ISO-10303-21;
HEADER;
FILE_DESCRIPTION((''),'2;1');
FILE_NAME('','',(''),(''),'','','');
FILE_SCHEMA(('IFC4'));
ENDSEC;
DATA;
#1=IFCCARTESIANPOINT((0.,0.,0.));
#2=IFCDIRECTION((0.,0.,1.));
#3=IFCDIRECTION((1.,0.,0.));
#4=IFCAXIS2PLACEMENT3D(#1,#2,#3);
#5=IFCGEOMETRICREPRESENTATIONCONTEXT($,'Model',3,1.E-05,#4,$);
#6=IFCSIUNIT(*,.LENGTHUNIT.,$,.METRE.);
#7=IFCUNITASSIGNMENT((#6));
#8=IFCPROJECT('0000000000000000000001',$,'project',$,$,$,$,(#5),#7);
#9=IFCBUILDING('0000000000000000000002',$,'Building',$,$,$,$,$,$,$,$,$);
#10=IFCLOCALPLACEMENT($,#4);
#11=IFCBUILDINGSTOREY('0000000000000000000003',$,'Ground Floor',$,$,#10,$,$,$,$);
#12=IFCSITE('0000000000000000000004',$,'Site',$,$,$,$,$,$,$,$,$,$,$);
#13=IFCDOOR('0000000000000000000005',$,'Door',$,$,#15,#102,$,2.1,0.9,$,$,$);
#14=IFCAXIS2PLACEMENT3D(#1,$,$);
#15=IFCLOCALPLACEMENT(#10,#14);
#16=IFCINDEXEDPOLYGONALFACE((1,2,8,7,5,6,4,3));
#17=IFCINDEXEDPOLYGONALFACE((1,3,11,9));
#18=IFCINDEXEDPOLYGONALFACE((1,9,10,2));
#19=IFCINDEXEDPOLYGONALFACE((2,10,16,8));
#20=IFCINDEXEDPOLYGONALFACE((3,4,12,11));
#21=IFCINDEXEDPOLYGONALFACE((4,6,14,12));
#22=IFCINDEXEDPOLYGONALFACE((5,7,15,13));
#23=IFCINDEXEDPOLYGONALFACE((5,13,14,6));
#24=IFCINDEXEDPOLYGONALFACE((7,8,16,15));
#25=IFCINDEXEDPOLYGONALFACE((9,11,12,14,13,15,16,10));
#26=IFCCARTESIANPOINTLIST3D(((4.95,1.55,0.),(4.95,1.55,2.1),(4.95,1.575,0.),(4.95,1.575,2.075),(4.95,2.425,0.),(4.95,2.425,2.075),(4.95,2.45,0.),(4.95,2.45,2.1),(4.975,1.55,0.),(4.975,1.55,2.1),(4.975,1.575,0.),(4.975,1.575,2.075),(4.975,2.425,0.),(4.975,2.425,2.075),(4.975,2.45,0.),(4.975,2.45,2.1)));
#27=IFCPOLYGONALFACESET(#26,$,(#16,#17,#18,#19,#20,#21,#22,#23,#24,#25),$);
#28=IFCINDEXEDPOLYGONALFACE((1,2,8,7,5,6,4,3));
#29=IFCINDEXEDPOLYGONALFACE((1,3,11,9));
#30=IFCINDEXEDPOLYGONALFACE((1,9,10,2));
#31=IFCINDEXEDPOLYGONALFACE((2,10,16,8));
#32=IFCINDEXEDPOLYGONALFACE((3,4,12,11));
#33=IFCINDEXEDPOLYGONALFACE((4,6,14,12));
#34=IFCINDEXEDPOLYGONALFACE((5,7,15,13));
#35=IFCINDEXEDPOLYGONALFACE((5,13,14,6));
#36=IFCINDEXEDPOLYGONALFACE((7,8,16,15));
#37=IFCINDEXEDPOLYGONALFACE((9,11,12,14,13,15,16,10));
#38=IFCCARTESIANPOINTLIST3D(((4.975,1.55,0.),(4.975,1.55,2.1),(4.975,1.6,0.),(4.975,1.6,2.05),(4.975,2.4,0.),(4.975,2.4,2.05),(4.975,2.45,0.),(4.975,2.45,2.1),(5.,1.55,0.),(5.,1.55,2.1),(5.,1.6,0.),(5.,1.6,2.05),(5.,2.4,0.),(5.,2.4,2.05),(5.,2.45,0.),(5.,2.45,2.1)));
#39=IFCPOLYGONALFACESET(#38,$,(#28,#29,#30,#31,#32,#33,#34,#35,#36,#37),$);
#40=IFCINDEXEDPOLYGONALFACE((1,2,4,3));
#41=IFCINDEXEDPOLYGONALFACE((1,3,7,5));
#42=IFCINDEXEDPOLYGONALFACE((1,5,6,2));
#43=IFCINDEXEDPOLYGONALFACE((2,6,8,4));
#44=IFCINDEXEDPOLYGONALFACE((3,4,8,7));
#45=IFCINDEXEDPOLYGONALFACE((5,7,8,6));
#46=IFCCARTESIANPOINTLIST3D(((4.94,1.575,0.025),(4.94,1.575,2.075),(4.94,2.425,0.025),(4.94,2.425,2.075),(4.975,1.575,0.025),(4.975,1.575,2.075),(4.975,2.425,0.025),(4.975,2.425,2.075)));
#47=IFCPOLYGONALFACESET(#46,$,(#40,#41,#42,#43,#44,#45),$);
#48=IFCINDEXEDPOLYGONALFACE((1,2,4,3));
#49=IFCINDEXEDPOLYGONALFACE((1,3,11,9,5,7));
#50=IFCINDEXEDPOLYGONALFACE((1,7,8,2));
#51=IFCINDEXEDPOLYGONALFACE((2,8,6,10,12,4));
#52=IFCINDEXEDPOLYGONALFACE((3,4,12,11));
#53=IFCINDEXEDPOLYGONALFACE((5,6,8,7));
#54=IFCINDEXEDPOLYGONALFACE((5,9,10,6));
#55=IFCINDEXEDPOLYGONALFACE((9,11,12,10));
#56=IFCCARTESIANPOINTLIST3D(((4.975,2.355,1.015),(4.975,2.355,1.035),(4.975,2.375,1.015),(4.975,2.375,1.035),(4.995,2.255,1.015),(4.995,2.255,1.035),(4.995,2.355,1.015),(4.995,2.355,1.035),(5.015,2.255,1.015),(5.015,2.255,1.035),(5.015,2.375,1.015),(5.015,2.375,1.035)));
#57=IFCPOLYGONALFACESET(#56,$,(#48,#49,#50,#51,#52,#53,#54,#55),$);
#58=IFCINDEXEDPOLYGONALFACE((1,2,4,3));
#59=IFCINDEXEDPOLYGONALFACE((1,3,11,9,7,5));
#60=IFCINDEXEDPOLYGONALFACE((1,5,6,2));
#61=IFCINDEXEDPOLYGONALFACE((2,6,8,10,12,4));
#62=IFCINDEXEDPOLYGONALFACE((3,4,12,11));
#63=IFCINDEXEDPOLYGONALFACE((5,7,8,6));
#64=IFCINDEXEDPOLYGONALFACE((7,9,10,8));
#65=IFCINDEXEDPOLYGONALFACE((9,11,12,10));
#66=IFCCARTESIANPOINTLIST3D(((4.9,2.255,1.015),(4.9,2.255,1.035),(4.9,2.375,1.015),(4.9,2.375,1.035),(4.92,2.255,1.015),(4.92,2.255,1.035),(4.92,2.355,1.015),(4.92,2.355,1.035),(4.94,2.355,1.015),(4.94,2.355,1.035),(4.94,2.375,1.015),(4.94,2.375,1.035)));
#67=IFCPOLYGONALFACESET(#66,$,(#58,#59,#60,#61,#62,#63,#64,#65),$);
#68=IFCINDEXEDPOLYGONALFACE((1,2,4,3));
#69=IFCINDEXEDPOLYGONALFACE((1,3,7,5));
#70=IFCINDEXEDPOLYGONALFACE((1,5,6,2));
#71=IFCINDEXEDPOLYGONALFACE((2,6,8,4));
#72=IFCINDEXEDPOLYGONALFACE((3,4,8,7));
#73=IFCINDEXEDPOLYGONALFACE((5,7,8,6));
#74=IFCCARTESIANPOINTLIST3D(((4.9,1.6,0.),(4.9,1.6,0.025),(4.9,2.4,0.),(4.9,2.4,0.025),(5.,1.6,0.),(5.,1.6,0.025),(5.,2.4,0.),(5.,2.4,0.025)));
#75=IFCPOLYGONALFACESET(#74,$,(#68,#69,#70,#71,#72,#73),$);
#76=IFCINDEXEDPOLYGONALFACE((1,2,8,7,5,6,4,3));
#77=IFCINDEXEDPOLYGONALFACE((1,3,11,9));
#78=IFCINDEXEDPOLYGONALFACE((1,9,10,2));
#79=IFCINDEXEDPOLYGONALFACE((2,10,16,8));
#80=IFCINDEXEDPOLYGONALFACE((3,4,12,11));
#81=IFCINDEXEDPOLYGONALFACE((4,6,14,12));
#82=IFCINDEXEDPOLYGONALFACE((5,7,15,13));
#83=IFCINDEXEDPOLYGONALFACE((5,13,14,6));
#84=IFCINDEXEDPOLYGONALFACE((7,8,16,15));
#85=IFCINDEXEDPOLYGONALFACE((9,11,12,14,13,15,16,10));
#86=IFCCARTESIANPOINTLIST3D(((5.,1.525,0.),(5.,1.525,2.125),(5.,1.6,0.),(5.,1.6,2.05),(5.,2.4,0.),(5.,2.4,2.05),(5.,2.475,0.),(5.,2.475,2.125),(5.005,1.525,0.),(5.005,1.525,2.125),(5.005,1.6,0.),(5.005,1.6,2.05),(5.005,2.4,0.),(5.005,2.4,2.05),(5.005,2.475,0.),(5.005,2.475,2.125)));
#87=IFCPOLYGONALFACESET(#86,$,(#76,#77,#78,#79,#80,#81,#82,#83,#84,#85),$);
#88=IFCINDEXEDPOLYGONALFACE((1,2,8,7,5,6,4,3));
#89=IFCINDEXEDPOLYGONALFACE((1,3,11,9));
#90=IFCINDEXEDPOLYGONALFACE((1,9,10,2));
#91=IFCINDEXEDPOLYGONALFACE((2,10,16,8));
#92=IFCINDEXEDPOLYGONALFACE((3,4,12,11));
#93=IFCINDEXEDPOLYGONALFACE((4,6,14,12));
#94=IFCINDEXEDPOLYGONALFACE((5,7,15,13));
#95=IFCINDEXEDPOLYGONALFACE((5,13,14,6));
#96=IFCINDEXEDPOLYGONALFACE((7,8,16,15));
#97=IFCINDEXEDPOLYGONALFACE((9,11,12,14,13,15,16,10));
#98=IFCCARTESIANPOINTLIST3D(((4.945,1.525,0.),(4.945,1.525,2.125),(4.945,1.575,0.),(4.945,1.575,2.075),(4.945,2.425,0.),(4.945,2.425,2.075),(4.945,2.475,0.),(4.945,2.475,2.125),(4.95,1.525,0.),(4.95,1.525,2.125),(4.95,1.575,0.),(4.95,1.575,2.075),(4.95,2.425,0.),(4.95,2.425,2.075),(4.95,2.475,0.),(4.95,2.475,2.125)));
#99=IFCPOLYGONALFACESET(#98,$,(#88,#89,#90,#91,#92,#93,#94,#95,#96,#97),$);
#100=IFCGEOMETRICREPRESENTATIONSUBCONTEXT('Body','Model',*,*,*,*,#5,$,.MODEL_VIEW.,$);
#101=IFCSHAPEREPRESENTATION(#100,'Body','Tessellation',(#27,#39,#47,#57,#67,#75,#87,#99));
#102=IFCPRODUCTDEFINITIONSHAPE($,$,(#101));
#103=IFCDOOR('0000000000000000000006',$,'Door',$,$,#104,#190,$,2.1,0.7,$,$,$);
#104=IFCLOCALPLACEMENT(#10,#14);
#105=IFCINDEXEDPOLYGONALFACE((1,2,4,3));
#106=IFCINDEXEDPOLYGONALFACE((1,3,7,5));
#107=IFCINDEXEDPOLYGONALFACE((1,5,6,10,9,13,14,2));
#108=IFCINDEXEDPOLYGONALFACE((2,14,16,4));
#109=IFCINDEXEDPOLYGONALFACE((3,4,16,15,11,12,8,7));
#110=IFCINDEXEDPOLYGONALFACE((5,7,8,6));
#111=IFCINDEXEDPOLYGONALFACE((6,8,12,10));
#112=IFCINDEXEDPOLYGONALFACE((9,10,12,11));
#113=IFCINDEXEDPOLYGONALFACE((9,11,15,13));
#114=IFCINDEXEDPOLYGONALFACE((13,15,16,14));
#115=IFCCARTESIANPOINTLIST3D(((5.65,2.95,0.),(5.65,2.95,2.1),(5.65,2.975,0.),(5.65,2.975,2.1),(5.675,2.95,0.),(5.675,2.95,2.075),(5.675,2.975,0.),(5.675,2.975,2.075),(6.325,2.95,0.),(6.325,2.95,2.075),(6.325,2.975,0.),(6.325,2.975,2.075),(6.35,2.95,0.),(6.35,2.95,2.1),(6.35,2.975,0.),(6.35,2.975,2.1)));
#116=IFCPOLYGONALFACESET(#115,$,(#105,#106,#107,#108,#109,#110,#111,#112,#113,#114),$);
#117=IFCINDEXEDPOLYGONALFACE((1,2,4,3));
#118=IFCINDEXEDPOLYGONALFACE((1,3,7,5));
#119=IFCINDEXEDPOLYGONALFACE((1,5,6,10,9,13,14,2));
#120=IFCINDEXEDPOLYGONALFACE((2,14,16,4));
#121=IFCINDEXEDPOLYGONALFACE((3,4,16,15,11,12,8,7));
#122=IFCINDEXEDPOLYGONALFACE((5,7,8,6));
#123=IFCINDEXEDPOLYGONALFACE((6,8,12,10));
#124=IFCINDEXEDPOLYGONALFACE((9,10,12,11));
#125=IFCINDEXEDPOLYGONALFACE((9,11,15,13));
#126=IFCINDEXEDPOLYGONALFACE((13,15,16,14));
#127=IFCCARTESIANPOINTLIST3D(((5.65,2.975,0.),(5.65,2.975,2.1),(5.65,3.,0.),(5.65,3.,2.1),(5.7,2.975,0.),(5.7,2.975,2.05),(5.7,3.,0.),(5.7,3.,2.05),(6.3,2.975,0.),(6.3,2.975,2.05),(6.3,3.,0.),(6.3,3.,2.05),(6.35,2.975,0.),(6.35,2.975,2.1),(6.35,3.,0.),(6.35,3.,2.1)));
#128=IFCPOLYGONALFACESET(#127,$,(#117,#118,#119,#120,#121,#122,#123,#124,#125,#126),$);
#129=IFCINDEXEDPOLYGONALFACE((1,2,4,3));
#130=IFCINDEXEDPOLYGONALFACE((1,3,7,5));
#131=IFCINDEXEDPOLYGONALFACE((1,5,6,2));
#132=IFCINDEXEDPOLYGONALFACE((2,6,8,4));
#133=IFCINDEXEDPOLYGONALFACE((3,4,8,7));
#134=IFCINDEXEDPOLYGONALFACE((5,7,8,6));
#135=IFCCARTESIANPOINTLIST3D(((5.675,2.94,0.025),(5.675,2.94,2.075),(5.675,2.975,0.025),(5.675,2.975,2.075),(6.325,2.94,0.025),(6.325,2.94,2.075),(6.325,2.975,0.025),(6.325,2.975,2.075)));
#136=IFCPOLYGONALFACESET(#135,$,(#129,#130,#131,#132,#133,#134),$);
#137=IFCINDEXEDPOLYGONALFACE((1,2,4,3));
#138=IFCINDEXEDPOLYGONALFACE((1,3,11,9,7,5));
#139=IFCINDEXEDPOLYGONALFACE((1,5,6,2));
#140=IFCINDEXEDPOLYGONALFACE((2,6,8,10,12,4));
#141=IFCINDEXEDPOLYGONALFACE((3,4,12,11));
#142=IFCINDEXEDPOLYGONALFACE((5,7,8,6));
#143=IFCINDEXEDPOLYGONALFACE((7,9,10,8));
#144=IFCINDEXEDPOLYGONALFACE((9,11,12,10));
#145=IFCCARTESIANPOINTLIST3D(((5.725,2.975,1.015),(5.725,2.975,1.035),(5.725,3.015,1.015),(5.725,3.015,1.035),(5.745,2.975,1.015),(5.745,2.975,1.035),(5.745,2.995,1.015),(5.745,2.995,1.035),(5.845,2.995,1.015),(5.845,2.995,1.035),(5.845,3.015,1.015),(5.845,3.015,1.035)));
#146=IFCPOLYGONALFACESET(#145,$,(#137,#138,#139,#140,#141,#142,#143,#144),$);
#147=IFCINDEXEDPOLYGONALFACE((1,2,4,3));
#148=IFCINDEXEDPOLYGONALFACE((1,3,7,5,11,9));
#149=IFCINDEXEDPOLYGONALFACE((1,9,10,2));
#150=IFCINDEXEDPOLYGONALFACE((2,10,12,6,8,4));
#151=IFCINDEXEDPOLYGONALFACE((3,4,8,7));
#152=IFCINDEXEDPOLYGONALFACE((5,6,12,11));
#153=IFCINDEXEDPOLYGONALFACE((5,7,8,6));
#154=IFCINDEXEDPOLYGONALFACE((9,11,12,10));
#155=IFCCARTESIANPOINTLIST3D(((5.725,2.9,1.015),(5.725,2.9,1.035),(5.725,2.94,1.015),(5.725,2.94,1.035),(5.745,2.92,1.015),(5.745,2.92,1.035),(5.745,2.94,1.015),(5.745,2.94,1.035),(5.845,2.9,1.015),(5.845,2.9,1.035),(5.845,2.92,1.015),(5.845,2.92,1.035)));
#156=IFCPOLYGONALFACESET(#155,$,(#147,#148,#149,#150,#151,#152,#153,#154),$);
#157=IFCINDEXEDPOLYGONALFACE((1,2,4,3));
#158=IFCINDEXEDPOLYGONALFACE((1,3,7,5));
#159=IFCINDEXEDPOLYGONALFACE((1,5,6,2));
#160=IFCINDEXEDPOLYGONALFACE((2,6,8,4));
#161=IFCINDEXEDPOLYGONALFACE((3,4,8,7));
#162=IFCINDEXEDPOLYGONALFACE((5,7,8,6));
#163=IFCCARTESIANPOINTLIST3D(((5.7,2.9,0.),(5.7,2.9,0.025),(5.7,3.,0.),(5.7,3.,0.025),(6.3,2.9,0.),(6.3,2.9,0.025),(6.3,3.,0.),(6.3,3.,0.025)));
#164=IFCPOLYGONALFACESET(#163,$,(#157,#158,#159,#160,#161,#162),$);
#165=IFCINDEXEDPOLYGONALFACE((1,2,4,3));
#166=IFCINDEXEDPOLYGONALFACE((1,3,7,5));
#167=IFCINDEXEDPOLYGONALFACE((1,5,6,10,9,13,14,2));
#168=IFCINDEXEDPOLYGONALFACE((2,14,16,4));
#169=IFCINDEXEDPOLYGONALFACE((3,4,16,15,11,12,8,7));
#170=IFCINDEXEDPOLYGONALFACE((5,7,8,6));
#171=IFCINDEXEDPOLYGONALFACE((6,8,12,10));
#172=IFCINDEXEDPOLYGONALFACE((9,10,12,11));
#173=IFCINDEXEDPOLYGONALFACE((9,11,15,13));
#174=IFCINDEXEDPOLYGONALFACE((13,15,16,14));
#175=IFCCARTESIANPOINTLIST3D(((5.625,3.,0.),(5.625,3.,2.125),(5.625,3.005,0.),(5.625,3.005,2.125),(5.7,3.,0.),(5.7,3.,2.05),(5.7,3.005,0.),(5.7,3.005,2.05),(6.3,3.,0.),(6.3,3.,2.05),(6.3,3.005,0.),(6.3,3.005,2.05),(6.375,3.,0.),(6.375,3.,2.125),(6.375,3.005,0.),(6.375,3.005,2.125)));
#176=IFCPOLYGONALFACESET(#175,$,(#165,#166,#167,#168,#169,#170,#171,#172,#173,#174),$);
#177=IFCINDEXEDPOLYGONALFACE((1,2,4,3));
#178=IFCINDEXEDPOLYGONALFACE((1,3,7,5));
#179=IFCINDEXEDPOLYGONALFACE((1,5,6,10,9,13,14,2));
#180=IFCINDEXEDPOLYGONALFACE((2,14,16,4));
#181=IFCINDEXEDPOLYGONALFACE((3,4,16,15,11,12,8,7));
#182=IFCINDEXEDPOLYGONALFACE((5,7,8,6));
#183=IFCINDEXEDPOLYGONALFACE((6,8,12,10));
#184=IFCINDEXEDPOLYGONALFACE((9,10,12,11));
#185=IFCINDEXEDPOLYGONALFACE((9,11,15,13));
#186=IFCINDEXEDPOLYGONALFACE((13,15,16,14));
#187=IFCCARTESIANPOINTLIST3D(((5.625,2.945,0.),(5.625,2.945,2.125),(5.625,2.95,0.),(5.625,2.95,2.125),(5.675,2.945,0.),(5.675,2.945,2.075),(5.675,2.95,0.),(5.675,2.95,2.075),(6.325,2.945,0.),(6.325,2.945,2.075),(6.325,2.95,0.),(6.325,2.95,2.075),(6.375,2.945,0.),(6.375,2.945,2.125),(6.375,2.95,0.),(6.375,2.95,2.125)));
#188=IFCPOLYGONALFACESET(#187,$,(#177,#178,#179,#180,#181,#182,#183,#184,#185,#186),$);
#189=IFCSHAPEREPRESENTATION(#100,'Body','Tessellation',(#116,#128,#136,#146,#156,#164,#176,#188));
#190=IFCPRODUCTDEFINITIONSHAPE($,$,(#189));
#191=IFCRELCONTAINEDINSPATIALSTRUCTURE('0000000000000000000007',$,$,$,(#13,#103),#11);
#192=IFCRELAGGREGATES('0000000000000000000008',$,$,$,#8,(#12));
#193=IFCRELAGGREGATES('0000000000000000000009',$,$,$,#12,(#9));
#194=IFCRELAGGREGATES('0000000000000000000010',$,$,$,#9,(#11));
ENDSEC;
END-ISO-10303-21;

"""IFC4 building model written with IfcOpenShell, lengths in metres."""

from ifc_helpers import new_model, si_unit, frame, origin_with_axes, place, context, subcontext, project, spatial, line, indexed_curve, outline, extrude, element, save


model = new_model("IFC4")

# Units and contexts
model_context = context("Model", 3, precision=1e-05, world=origin_with_axes())
body_context = subcontext(model_context, "Body", "Model", "MODEL_VIEW")
ifc_project = project(units=[si_unit("LENGTHUNIT", "METRE")], contexts=[model_context])

# Site, building, storey
site = spatial("IfcSite", under=ifc_project, Name="Site")
building = spatial("IfcBuilding", under=site, Name="Building")
storey_placement = place(None, origin_with_axes())
storey = spatial("IfcBuildingStorey", under=building, at=storey_placement, Name="Ground Floor")

# Doors
door_1_placement = place(storey_placement, frame((5.0, 1.55, 0.0), z_axis=(0.0, 0.0, 1.0), x_axis=(0.0, 1.0, 0.0)))
element("IfcDoor", 1, at=door_1_placement, inside=storey, Name="Door", OverallHeight=2.1, OverallWidth=0.9, context=body_context, shape_type="SweptSolid", body=[
    extrude(outline(indexed_curve([(0.0, 0.0), (0.0, 2.1), (0.9, 2.1), (0.9, 0.0), (0.875, 0.0), (0.875, 2.075), (0.025, 2.075), (0.025, 0.0)], segments=[line(1, 2, 3, 4, 5, 6, 7, 8, 1)])), frame((0.0, 0.025, 0.0), z_axis=(0.0, -1.0, 0.0), x_axis=(1.0, 0.0, 0.0)), (0.0, 0.0, -1.0), 0.025),
    extrude(outline(indexed_curve([(0.0, 0.0), (0.0, 2.1), (0.9, 2.1), (0.9, 0.0), (0.85, 0.0), (0.85, 2.05), (0.05, 2.05), (0.05, 0.0)], segments=[line(1, 2, 3, 4, 5, 6, 7, 8, 1)])), frame((0.0, 0.0, 0.0), z_axis=(0.0, -1.0, 0.0), x_axis=(1.0, 0.0, 0.0)), (0.0, 0.0, -1.0), 0.025),
    extrude(outline(indexed_curve([(0.0, 0.0), (0.85, 0.0), (0.85, 0.035), (0.0, 0.035)], segments=[line(1, 2, 3, 4, 1)])), frame((0.025, 0.025, 0.025), z_axis=(0.0, 0.0, 1.0), x_axis=(1.0, 0.0, 0.0)), (0.0, 0.0, 1.0), 2.05),
    extrude(outline(indexed_curve([(0.0, 0.0), (0.0, -0.04), (-0.12, -0.04), (-0.12, -0.02), (-0.02, -0.02), (-0.02, 0.0)], segments=[line(1, 2, 3, 4, 5, 6, 1)])), frame((0.825, 0.025, 1.015), z_axis=(0.0, 0.0, 1.0), x_axis=(1.0, 0.0, 0.0)), (0.0, 0.0, 1.0), 0.02),
    extrude(outline(indexed_curve([(0.0, 0.0), (0.0, 0.04), (-0.12, 0.04), (-0.12, 0.02), (-0.02, 0.02), (-0.02, 0.0)], segments=[line(1, 2, 3, 4, 5, 6, 1)])), frame((0.825, 0.06, 1.015), z_axis=(0.0, 0.0, 1.0), x_axis=(1.0, 0.0, 0.0)), (0.0, 0.0, 1.0), 0.02),
    extrude(outline(indexed_curve([(0.0, 0.0), (0.8, 0.0), (0.8, 0.1), (0.0, 0.1)], segments=[line(1, 2, 3, 4, 1)])), frame((0.05, 0.0, 0.0), z_axis=(0.0, 0.0, 1.0), x_axis=(1.0, 0.0, 0.0)), (0.0, 0.0, 1.0), 0.025),
    extrude(outline(indexed_curve([(0.0, 0.0), (0.0, 2.125), (0.95, 2.125), (0.95, 0.0), (0.875, 0.0), (0.875, 2.05), (0.075, 2.05), (0.075, 0.0)], segments=[line(1, 2, 3, 4, 5, 6, 7, 8, 1)])), frame((-0.025, -0.005, 0.0), z_axis=(0.0, -1.0, 0.0), x_axis=(1.0, 0.0, 0.0)), (0.0, 0.0, -1.0), 0.005),
    extrude(outline(indexed_curve([(0.0, 0.0), (0.0, 2.125), (0.95, 2.125), (0.95, 0.0), (0.9, 0.0), (0.9, 2.075), (0.05, 2.075), (0.05, 0.0)], segments=[line(1, 2, 3, 4, 5, 6, 7, 8, 1)])), frame((-0.025, 0.05, 0.0), z_axis=(0.0, -1.0, 0.0), x_axis=(1.0, 0.0, 0.0)), (0.0, 0.0, -1.0), 0.005),
])
door_2_placement = place(storey_placement, frame((6.35, 3.0, 0.0), z_axis=(0.0, 0.0, 1.0), x_axis=(-1.0, 0.0, 0.0)))
element("IfcDoor", 2, at=door_2_placement, inside=storey, Name="Door", OverallHeight=2.1, OverallWidth=0.7, context=body_context, shape_type="SweptSolid", body=[
    extrude(outline(indexed_curve([(0.0, 0.0), (0.0, 2.1), (0.7, 2.1), (0.7, 0.0), (0.675, 0.0), (0.675, 2.075), (0.025, 2.075), (0.025, 0.0)], segments=[line(1, 2, 3, 4, 5, 6, 7, 8, 1)])), frame((0.0, 0.025, 0.0), z_axis=(0.0, -1.0, 0.0), x_axis=(1.0, 0.0, 0.0)), (0.0, 0.0, -1.0), 0.025),
    extrude(outline(indexed_curve([(0.0, 0.0), (0.0, 2.1), (0.7, 2.1), (0.7, 0.0), (0.65, 0.0), (0.65, 2.05), (0.05, 2.05), (0.05, 0.0)], segments=[line(1, 2, 3, 4, 5, 6, 7, 8, 1)])), frame((0.0, 0.0, 0.0), z_axis=(0.0, -1.0, 0.0), x_axis=(1.0, 0.0, 0.0)), (0.0, 0.0, -1.0), 0.025),
    extrude(outline(indexed_curve([(0.0, 0.0), (0.65, 0.0), (0.65, 0.035), (0.0, 0.035)], segments=[line(1, 2, 3, 4, 1)])), frame((0.025, 0.025, 0.025), z_axis=(0.0, 0.0, 1.0), x_axis=(1.0, 0.0, 0.0)), (0.0, 0.0, 1.0), 2.05),
    extrude(outline(indexed_curve([(0.0, 0.0), (0.0, -0.04), (-0.12, -0.04), (-0.12, -0.02), (-0.02, -0.02), (-0.02, 0.0)], segments=[line(1, 2, 3, 4, 5, 6, 1)])), frame((0.625, 0.025, 1.015), z_axis=(0.0, 0.0, 1.0), x_axis=(1.0, 0.0, 0.0)), (0.0, 0.0, 1.0), 0.02),
    extrude(outline(indexed_curve([(0.0, 0.0), (0.0, 0.04), (-0.12, 0.04), (-0.12, 0.02), (-0.02, 0.02), (-0.02, 0.0)], segments=[line(1, 2, 3, 4, 5, 6, 1)])), frame((0.625, 0.06, 1.015), z_axis=(0.0, 0.0, 1.0), x_axis=(1.0, 0.0, 0.0)), (0.0, 0.0, 1.0), 0.02),
    extrude(outline(indexed_curve([(0.0, 0.0), (0.6, 0.0), (0.6, 0.1), (0.0, 0.1)], segments=[line(1, 2, 3, 4, 1)])), frame((0.05, 0.0, 0.0), z_axis=(0.0, 0.0, 1.0), x_axis=(1.0, 0.0, 0.0)), (0.0, 0.0, 1.0), 0.025),
    extrude(outline(indexed_curve([(0.0, 0.0), (0.0, 2.125), (0.75, 2.125), (0.75, 0.0), (0.675, 0.0), (0.675, 2.05), (0.075, 2.05), (0.075, 0.0)], segments=[line(1, 2, 3, 4, 5, 6, 7, 8, 1)])), frame((-0.025, -0.005, 0.0), z_axis=(0.0, -1.0, 0.0), x_axis=(1.0, 0.0, 0.0)), (0.0, 0.0, -1.0), 0.005),
    extrude(outline(indexed_curve([(0.0, 0.0), (0.0, 2.125), (0.75, 2.125), (0.75, 0.0), (0.7, 0.0), (0.7, 2.075), (0.05, 2.075), (0.05, 0.0)], segments=[line(1, 2, 3, 4, 5, 6, 7, 8, 1)])), frame((-0.025, 0.05, 0.0), z_axis=(0.0, -1.0, 0.0), x_axis=(1.0, 0.0, 0.0)), (0.0, 0.0, -1.0), 0.005),
])

save(model, "model.ifc")
